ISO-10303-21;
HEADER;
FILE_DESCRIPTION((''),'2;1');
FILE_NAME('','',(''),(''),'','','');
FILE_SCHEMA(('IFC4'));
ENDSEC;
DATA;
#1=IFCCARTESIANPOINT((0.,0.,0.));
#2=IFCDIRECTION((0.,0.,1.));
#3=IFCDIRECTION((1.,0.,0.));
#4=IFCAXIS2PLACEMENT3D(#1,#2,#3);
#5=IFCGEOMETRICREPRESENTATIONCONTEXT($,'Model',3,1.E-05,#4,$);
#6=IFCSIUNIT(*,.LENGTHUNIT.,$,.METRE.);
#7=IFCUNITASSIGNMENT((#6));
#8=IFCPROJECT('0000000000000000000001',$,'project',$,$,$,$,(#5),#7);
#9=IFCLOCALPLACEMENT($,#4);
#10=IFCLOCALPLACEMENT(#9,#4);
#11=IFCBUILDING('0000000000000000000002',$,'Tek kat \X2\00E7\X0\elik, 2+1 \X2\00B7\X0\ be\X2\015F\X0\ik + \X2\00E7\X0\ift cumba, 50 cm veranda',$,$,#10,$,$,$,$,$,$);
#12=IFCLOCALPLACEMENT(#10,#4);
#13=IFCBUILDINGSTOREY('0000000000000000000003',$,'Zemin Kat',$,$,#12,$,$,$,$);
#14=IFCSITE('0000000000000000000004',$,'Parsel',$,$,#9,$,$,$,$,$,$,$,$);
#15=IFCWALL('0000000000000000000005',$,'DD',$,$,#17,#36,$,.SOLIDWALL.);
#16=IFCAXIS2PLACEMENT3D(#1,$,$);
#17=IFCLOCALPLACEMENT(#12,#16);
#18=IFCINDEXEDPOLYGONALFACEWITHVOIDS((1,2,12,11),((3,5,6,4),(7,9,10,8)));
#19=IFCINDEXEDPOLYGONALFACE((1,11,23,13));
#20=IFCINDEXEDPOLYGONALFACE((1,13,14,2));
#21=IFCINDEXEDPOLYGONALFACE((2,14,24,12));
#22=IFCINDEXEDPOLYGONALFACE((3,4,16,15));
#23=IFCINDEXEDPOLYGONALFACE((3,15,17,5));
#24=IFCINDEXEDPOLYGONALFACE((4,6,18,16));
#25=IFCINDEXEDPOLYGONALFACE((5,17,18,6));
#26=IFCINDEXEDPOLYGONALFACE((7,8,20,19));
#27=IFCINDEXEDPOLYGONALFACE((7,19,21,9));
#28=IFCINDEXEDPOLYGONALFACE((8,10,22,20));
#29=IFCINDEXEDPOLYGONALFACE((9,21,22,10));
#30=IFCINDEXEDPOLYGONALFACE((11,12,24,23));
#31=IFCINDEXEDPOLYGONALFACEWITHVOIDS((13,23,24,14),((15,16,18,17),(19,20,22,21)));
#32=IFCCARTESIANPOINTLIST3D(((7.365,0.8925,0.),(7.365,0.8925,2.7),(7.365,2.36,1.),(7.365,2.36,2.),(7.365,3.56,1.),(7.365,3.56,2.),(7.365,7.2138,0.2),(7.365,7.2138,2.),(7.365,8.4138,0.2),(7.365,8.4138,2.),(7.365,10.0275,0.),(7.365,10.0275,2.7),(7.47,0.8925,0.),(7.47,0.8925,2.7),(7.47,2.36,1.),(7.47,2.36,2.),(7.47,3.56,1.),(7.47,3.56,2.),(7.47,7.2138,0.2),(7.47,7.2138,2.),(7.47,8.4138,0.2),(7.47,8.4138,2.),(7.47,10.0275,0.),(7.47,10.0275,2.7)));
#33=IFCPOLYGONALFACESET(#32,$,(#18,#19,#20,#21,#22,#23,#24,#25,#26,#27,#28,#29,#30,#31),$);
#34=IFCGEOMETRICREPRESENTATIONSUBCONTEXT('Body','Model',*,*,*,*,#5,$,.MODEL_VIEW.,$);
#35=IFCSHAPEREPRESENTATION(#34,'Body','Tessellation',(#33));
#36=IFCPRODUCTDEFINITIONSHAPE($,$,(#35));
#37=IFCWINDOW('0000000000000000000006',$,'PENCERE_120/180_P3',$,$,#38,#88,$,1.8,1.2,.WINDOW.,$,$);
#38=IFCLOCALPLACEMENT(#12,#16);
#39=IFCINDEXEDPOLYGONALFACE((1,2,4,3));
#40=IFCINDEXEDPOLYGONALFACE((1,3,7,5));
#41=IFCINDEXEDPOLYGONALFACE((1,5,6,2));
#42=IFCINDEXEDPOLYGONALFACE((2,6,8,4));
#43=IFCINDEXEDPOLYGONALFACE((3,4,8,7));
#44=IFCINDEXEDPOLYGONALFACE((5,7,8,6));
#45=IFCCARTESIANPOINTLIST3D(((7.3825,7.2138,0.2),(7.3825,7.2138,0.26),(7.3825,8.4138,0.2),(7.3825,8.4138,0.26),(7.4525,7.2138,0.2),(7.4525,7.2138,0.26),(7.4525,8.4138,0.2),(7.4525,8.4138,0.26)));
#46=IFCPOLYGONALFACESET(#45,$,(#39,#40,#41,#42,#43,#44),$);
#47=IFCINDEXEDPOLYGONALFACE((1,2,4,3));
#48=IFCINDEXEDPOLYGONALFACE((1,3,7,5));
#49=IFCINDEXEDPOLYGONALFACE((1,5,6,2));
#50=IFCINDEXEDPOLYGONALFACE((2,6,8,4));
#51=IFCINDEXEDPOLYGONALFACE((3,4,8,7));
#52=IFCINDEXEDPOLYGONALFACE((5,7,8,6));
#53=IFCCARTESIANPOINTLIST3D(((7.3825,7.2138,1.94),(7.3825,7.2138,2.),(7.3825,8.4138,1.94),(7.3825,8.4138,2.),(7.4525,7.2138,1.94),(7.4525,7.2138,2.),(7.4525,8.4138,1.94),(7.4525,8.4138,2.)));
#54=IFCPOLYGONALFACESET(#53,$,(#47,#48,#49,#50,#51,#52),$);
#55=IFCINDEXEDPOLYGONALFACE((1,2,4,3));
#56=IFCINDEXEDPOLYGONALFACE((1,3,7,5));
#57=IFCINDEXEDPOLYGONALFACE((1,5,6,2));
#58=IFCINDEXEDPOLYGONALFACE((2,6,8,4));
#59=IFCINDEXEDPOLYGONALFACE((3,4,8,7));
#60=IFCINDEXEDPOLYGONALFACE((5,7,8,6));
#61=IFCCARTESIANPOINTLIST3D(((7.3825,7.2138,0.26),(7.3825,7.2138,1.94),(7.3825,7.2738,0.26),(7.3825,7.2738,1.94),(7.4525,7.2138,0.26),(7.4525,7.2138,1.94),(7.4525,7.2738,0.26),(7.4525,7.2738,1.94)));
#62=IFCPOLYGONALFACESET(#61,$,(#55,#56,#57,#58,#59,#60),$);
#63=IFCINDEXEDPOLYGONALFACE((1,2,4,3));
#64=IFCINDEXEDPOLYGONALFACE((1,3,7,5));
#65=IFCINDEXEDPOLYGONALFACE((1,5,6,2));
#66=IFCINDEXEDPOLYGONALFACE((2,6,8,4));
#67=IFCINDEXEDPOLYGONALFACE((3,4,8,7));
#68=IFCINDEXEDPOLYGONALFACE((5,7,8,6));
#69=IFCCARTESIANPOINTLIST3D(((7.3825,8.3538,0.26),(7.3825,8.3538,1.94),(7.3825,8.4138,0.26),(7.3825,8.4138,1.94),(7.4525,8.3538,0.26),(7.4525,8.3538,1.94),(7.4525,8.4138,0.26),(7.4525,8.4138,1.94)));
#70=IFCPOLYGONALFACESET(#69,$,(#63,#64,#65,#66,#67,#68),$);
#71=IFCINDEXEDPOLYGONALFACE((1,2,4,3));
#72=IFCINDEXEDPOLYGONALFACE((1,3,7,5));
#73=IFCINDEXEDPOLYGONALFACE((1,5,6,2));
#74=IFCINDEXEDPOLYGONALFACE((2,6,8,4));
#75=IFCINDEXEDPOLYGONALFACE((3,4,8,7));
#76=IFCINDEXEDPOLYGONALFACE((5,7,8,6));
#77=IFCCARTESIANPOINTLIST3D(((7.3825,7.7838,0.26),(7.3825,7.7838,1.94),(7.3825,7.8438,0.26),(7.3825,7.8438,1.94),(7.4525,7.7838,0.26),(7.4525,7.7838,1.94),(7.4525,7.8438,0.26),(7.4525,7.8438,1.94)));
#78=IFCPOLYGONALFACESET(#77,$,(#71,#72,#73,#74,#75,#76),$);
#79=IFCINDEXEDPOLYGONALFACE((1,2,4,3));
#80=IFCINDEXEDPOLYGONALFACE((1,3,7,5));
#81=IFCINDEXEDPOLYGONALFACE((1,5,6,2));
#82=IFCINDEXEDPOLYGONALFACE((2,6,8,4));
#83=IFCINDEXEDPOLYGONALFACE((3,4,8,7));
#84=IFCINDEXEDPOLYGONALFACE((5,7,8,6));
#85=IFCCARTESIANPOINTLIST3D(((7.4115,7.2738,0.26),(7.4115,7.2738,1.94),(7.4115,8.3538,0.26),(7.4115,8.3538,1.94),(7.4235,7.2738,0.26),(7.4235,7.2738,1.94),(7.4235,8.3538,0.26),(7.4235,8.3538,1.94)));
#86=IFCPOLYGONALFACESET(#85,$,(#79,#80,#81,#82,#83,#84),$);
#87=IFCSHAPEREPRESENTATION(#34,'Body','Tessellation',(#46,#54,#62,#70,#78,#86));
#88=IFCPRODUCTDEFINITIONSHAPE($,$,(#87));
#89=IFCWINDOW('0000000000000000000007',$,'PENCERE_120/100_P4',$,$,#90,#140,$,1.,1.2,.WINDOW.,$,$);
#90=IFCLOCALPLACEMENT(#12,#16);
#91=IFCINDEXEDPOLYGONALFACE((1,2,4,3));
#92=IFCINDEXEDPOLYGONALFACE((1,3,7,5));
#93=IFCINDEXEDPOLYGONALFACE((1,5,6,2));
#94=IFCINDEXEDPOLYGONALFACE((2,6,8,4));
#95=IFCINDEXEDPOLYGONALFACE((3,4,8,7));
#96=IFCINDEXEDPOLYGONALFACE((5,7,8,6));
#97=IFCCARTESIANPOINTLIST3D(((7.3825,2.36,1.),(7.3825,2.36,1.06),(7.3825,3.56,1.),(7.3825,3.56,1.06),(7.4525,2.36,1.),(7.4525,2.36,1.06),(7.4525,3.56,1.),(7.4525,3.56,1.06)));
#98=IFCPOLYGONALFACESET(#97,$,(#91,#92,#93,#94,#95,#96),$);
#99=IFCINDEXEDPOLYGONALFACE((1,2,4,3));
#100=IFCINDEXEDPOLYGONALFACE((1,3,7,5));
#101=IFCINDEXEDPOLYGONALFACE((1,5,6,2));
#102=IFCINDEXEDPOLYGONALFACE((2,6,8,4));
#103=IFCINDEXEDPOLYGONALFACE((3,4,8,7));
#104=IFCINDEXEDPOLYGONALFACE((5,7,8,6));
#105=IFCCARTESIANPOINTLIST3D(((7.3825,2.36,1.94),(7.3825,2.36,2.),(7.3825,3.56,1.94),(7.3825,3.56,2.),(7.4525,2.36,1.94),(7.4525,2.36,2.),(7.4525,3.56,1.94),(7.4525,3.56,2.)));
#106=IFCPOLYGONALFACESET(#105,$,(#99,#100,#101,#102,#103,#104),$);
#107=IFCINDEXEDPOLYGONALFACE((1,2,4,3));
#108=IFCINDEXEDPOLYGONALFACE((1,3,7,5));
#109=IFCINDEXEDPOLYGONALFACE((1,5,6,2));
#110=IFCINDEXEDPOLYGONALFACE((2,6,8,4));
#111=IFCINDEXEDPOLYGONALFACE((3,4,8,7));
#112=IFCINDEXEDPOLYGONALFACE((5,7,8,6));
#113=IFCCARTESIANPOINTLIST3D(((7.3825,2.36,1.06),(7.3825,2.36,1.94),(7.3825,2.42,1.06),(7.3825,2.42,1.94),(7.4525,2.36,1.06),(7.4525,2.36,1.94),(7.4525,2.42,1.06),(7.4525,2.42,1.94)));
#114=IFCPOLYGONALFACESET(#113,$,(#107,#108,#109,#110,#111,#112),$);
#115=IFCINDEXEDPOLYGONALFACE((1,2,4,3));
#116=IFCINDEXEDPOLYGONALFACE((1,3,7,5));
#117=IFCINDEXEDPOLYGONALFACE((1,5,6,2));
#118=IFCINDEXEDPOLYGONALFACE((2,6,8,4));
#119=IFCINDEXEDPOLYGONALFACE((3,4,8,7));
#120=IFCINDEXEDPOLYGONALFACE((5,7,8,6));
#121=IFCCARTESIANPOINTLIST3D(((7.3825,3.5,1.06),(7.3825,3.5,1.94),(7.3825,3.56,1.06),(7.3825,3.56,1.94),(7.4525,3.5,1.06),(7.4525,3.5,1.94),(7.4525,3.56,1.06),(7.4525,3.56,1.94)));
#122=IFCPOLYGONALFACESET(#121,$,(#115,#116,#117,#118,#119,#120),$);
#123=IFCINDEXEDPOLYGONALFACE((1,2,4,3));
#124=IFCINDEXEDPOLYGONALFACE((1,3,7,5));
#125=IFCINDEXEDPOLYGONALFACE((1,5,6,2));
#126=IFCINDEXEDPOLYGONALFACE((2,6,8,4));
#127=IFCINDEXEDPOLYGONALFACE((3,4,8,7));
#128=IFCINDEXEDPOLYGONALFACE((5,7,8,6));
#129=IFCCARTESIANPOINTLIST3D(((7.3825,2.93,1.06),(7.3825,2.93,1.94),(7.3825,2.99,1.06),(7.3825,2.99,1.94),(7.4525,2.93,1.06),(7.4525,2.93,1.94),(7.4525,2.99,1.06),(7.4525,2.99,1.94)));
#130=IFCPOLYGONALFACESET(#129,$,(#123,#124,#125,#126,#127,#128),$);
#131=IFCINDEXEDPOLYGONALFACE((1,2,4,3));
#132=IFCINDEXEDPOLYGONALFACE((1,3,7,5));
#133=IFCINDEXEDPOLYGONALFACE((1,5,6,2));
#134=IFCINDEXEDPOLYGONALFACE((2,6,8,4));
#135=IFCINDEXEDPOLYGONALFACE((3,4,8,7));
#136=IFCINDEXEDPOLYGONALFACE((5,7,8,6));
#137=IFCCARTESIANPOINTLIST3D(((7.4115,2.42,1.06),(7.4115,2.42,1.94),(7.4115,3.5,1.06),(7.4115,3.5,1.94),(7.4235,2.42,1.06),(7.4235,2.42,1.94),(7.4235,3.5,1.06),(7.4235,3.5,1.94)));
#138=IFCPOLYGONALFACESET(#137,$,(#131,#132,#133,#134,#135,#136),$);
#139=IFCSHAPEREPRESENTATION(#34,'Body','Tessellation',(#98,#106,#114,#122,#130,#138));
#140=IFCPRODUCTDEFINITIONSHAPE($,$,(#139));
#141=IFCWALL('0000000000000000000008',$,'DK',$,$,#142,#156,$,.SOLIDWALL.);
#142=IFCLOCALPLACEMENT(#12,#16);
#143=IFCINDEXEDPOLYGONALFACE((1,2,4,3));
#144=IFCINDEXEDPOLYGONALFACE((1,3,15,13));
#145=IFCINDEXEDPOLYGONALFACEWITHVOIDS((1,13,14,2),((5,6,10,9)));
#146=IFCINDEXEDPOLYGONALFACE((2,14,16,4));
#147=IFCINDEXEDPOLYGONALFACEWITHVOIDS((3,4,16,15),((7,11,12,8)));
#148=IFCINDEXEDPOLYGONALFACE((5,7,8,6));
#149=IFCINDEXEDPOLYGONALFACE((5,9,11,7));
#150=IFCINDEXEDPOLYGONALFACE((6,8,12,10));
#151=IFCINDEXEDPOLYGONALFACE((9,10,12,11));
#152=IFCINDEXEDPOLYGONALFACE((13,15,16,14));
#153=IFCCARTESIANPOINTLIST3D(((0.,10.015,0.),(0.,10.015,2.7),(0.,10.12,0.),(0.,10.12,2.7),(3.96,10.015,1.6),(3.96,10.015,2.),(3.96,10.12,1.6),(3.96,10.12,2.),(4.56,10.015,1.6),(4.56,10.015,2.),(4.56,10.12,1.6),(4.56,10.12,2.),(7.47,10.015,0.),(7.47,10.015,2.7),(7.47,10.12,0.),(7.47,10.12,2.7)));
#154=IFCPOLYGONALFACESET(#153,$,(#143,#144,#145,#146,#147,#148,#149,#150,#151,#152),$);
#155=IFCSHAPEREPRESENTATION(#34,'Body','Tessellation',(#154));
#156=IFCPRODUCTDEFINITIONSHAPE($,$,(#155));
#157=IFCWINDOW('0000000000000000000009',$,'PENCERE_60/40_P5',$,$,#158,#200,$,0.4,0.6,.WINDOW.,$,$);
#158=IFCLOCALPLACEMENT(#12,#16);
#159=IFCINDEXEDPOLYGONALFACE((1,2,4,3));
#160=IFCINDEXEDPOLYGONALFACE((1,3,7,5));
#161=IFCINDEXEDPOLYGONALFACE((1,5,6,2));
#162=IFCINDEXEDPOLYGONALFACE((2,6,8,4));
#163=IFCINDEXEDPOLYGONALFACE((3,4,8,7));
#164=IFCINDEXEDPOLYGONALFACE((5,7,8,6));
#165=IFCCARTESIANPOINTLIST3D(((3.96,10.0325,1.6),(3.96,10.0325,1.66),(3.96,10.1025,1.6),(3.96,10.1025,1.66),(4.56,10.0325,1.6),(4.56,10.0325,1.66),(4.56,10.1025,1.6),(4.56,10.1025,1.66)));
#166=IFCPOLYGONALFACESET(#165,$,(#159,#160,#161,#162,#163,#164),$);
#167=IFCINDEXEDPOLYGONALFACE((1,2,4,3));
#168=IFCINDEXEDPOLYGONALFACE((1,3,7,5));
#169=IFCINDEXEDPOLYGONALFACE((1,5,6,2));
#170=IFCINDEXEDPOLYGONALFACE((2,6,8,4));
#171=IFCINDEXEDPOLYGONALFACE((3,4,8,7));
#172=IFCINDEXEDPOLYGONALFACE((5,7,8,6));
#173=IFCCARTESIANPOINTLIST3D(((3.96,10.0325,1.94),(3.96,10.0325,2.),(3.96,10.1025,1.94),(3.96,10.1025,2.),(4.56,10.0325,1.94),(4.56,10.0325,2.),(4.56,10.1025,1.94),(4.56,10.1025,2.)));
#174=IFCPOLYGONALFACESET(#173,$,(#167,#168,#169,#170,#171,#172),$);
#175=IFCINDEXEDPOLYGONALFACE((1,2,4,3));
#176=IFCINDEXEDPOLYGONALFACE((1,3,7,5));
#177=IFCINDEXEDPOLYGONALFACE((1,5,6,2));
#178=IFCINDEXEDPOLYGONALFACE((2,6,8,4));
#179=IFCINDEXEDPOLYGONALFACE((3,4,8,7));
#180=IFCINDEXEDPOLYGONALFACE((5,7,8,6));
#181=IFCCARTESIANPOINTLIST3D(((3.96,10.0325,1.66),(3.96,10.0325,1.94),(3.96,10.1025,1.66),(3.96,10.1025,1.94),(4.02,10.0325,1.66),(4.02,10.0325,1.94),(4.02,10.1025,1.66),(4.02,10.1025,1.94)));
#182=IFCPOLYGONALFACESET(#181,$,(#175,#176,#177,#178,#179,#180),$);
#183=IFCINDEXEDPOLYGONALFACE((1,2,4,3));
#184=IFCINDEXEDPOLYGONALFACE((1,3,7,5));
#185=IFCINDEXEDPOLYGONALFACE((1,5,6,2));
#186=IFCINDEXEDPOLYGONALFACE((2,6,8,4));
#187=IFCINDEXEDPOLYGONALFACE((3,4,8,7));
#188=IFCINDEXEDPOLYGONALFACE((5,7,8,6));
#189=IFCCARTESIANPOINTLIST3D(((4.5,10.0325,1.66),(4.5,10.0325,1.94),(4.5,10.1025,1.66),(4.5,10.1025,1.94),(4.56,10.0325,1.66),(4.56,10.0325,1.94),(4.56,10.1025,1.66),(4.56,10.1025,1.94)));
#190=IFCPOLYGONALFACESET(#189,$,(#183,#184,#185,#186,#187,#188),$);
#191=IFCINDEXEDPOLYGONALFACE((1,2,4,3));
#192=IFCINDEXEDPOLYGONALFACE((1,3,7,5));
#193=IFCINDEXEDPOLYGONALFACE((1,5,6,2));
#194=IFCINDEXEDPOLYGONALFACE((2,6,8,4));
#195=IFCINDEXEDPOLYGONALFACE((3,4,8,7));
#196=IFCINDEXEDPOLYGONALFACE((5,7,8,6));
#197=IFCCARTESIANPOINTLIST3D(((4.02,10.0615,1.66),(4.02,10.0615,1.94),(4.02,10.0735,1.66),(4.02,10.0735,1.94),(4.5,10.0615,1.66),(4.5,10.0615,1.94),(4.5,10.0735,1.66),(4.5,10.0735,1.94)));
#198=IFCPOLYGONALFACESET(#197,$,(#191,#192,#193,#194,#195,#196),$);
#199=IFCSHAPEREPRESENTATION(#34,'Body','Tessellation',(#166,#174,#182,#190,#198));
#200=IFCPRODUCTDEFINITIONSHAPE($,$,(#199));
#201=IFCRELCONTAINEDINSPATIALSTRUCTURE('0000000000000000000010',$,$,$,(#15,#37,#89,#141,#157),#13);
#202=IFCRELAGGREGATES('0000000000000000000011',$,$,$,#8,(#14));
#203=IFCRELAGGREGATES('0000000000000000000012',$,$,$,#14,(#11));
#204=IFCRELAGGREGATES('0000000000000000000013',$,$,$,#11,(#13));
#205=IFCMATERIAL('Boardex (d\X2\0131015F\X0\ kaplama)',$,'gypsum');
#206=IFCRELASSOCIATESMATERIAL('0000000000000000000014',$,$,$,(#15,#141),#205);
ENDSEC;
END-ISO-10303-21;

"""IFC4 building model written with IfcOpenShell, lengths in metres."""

from ifc_helpers import new_model, si_unit, frame, origin_with_axes, place, context, subcontext, project, spatial, line, indexed_curve, outline, extrude, material, element, fill, save


model = new_model("IFC4")

# Units and contexts
model_context = context("Model", 3, precision=1e-05, world=origin_with_axes())
body_context = subcontext(model_context, "Body", "Model", "MODEL_VIEW")
ifc_project = project(units=[si_unit("LENGTHUNIT", "METRE")], contexts=[model_context])

# Site, building, storey
site_placement = place(None, origin_with_axes())
site = spatial("IfcSite", under=ifc_project, at=site_placement, Name="Parsel")
building_placement = place(site_placement, origin_with_axes())
building = spatial("IfcBuilding", under=site, at=building_placement, Name="Tek kat çelik, 2+1 · beşik + çift cumba, 50 cm veranda")
storey_placement = place(building_placement, origin_with_axes())
storey = spatial("IfcBuildingStorey", under=building, at=storey_placement, Name="Zemin Kat")

# Shared definitions
ifc_material_1 = material(Name="Boardex (dış kaplama)", Category="gypsum")

# Wall, openings, windows
wall_1_placement = place(storey_placement, origin_with_axes())
wall_1 = element("IfcWall", 1, at=wall_1_placement, inside=storey, material=ifc_material_1, Name="DD", PredefinedType="SOLIDWALL", context=body_context, shape_type="SweptSolid", body=[
    extrude(outline(indexed_curve([(0.0, 0.0), (0.105, 0.0), (0.105, 9.135), (0.0, 9.135)], segments=[line(1, 2, 3, 4, 1)])), frame((7.365, 0.8925, 0.0), z_axis=(0.0, 0.0, 1.0), x_axis=(1.0, 0.0, 0.0)), (0.0, 0.0, 1.0), 2.7),
])
opening_1_placement = place(wall_1_placement, origin_with_axes())
opening_1 = element("IfcOpeningElement", 2, at=opening_1_placement, cuts=wall_1, PredefinedType="OPENING", context=body_context, shape_type="SweptSolid", body=[
    extrude(outline(indexed_curve([(0.0, 0.0), (0.145, 0.0), (0.145, 1.2), (0.0, 1.2)], segments=[line(1, 2, 3, 4, 1)])), frame((7.345, 7.2138, 0.2), z_axis=(0.0, 0.0, 1.0), x_axis=(1.0, 0.0, 0.0)), (0.0, 0.0, 1.0), 1.8),
])
opening_2_placement = place(wall_1_placement, origin_with_axes())
opening_2 = element("IfcOpeningElement", 3, at=opening_2_placement, cuts=wall_1, PredefinedType="OPENING", context=body_context, shape_type="SweptSolid", body=[
    extrude(outline(indexed_curve([(0.0, 0.0), (0.145, 0.0), (0.145, 1.2), (0.0, 1.2)], segments=[line(1, 2, 3, 4, 1)])), frame((7.345, 2.36, 1.0), z_axis=(0.0, 0.0, 1.0), x_axis=(1.0, 0.0, 0.0)), (0.0, 0.0, 1.0), 1.0),
])
window_1_placement = place(storey_placement, origin_with_axes())
window_1 = element("IfcWindow", 4, at=window_1_placement, inside=storey, Name="PENCERE_120/180_P3", OverallHeight=1.8, OverallWidth=1.2, PredefinedType="WINDOW", context=body_context, shape_type="SweptSolid", body=[
    extrude(outline(indexed_curve([(0.0, 0.0), (0.07, 0.0), (0.07, 1.2), (0.0, 1.2)], segments=[line(1, 2, 3, 4, 1)])), frame((7.3825, 7.2138, 0.2), z_axis=(0.0, 0.0, 1.0), x_axis=(1.0, 0.0, 0.0)), (0.0, 0.0, 1.0), 0.06),
    extrude(outline(indexed_curve([(0.0, 0.0), (0.07, 0.0), (0.07, 1.2), (0.0, 1.2)], segments=[line(1, 2, 3, 4, 1)])), frame((7.3825, 7.2138, 1.94), z_axis=(0.0, 0.0, 1.0), x_axis=(1.0, 0.0, 0.0)), (0.0, 0.0, 1.0), 0.06),
    extrude(outline(indexed_curve([(0.0, 0.0), (0.07, 0.0), (0.07, 0.06), (0.0, 0.06)], segments=[line(1, 2, 3, 4, 1)])), frame((7.3825, 7.2138, 0.26), z_axis=(0.0, 0.0, 1.0), x_axis=(1.0, 0.0, 0.0)), (0.0, 0.0, 1.0), 1.68),
    extrude(outline(indexed_curve([(0.0, 0.0), (0.07, 0.0), (0.07, 0.06), (0.0, 0.06)], segments=[line(1, 2, 3, 4, 1)])), frame((7.3825, 8.3538, 0.26), z_axis=(0.0, 0.0, 1.0), x_axis=(1.0, 0.0, 0.0)), (0.0, 0.0, 1.0), 1.68),
    extrude(outline(indexed_curve([(0.0, 0.0), (0.07, 0.0), (0.07, 0.06), (0.0, 0.06)], segments=[line(1, 2, 3, 4, 1)])), frame((7.3825, 7.7838, 0.26), z_axis=(0.0, 0.0, 1.0), x_axis=(1.0, 0.0, 0.0)), (0.0, 0.0, 1.0), 1.68),
    extrude(outline(indexed_curve([(0.0, 0.0), (0.012, 0.0), (0.012, 1.08), (0.0, 1.08)], segments=[line(1, 2, 3, 4, 1)])), frame((7.4115, 7.2738, 0.26), z_axis=(0.0, 0.0, 1.0), x_axis=(1.0, 0.0, 0.0)), (0.0, 0.0, 1.0), 1.68),
])
fill(opening_1, window_1)
window_2_placement = place(storey_placement, origin_with_axes())
window_2 = element("IfcWindow", 5, at=window_2_placement, inside=storey, Name="PENCERE_120/100_P4", OverallHeight=1.0, OverallWidth=1.2, PredefinedType="WINDOW", context=body_context, shape_type="SweptSolid", body=[
    extrude(outline(indexed_curve([(0.0, 0.0), (0.07, 0.0), (0.07, 1.2), (0.0, 1.2)], segments=[line(1, 2, 3, 4, 1)])), frame((7.3825, 2.36, 1.0), z_axis=(0.0, 0.0, 1.0), x_axis=(1.0, 0.0, 0.0)), (0.0, 0.0, 1.0), 0.06),
    extrude(outline(indexed_curve([(0.0, 0.0), (0.07, 0.0), (0.07, 1.2), (0.0, 1.2)], segments=[line(1, 2, 3, 4, 1)])), frame((7.3825, 2.36, 1.94), z_axis=(0.0, 0.0, 1.0), x_axis=(1.0, 0.0, 0.0)), (0.0, 0.0, 1.0), 0.06),
    extrude(outline(indexed_curve([(0.0, 0.0), (0.07, 0.0), (0.07, 0.06), (0.0, 0.06)], segments=[line(1, 2, 3, 4, 1)])), frame((7.3825, 2.36, 1.06), z_axis=(0.0, 0.0, 1.0), x_axis=(1.0, 0.0, 0.0)), (0.0, 0.0, 1.0), 0.88),
    extrude(outline(indexed_curve([(0.0, 0.0), (0.07, 0.0), (0.07, 0.06), (0.0, 0.06)], segments=[line(1, 2, 3, 4, 1)])), frame((7.3825, 3.5, 1.06), z_axis=(0.0, 0.0, 1.0), x_axis=(1.0, 0.0, 0.0)), (0.0, 0.0, 1.0), 0.88),
    extrude(outline(indexed_curve([(0.0, 0.0), (0.07, 0.0), (0.07, 0.06), (0.0, 0.06)], segments=[line(1, 2, 3, 4, 1)])), frame((7.3825, 2.93, 1.06), z_axis=(0.0, 0.0, 1.0), x_axis=(1.0, 0.0, 0.0)), (0.0, 0.0, 1.0), 0.88),
    extrude(outline(indexed_curve([(0.0, 0.0), (0.012, 0.0), (0.012, 1.08), (0.0, 1.08)], segments=[line(1, 2, 3, 4, 1)])), frame((7.4115, 2.42, 1.06), z_axis=(0.0, 0.0, 1.0), x_axis=(1.0, 0.0, 0.0)), (0.0, 0.0, 1.0), 0.88),
])
fill(opening_2, window_2)

# Wall, opening, window
wall_2_placement = place(storey_placement, origin_with_axes())
wall_2 = element("IfcWall", 6, at=wall_2_placement, inside=storey, material=ifc_material_1, Name="DK", PredefinedType="SOLIDWALL", context=body_context, shape_type="SweptSolid", body=[
    extrude(outline(indexed_curve([(0.0, 0.0), (7.47, 0.0), (7.47, 0.105), (0.0, 0.105)], segments=[line(1, 2, 3, 4, 1)])), frame((0.0, 10.015, 0.0), z_axis=(0.0, 0.0, 1.0), x_axis=(1.0, 0.0, 0.0)), (0.0, 0.0, 1.0), 2.7),
])
opening_3_placement = place(wall_2_placement, origin_with_axes())
opening_3 = element("IfcOpeningElement", 7, at=opening_3_placement, cuts=wall_2, PredefinedType="OPENING", context=body_context, shape_type="SweptSolid", body=[
    extrude(outline(indexed_curve([(0.0, 0.0), (0.6, 0.0), (0.6, 0.145), (0.0, 0.145)], segments=[line(1, 2, 3, 4, 1)])), frame((3.96, 9.995, 1.6), z_axis=(0.0, 0.0, 1.0), x_axis=(1.0, 0.0, 0.0)), (0.0, 0.0, 1.0), 0.4),
])
window_3_placement = place(storey_placement, origin_with_axes())
window_3 = element("IfcWindow", 8, at=window_3_placement, inside=storey, Name="PENCERE_60/40_P5", OverallHeight=0.4, OverallWidth=0.6, PredefinedType="WINDOW", context=body_context, shape_type="SweptSolid", body=[
    extrude(outline(indexed_curve([(0.0, 0.0), (0.6, 0.0), (0.6, 0.07), (0.0, 0.07)], segments=[line(1, 2, 3, 4, 1)])), frame((3.96, 10.0325, 1.6), z_axis=(0.0, 0.0, 1.0), x_axis=(1.0, 0.0, 0.0)), (0.0, 0.0, 1.0), 0.06),
    extrude(outline(indexed_curve([(0.0, 0.0), (0.6, 0.0), (0.6, 0.07), (0.0, 0.07)], segments=[line(1, 2, 3, 4, 1)])), frame((3.96, 10.0325, 1.94), z_axis=(0.0, 0.0, 1.0), x_axis=(1.0, 0.0, 0.0)), (0.0, 0.0, 1.0), 0.06),
    extrude(outline(indexed_curve([(0.0, 0.0), (0.06, 0.0), (0.06, 0.07), (0.0, 0.07)], segments=[line(1, 2, 3, 4, 1)])), frame((3.96, 10.0325, 1.66), z_axis=(0.0, 0.0, 1.0), x_axis=(1.0, 0.0, 0.0)), (0.0, 0.0, 1.0), 0.28),
    extrude(outline(indexed_curve([(0.0, 0.0), (0.06, 0.0), (0.06, 0.07), (0.0, 0.07)], segments=[line(1, 2, 3, 4, 1)])), frame((4.5, 10.0325, 1.66), z_axis=(0.0, 0.0, 1.0), x_axis=(1.0, 0.0, 0.0)), (0.0, 0.0, 1.0), 0.28),
    extrude(outline(indexed_curve([(0.0, 0.0), (0.48, 0.0), (0.48, 0.012), (0.0, 0.012)], segments=[line(1, 2, 3, 4, 1)])), frame((4.02, 10.0615, 1.66), z_axis=(0.0, 0.0, 1.0), x_axis=(1.0, 0.0, 0.0)), (0.0, 0.0, 1.0), 0.28),
])
fill(opening_3, window_3)

save(model, "model.ifc")
